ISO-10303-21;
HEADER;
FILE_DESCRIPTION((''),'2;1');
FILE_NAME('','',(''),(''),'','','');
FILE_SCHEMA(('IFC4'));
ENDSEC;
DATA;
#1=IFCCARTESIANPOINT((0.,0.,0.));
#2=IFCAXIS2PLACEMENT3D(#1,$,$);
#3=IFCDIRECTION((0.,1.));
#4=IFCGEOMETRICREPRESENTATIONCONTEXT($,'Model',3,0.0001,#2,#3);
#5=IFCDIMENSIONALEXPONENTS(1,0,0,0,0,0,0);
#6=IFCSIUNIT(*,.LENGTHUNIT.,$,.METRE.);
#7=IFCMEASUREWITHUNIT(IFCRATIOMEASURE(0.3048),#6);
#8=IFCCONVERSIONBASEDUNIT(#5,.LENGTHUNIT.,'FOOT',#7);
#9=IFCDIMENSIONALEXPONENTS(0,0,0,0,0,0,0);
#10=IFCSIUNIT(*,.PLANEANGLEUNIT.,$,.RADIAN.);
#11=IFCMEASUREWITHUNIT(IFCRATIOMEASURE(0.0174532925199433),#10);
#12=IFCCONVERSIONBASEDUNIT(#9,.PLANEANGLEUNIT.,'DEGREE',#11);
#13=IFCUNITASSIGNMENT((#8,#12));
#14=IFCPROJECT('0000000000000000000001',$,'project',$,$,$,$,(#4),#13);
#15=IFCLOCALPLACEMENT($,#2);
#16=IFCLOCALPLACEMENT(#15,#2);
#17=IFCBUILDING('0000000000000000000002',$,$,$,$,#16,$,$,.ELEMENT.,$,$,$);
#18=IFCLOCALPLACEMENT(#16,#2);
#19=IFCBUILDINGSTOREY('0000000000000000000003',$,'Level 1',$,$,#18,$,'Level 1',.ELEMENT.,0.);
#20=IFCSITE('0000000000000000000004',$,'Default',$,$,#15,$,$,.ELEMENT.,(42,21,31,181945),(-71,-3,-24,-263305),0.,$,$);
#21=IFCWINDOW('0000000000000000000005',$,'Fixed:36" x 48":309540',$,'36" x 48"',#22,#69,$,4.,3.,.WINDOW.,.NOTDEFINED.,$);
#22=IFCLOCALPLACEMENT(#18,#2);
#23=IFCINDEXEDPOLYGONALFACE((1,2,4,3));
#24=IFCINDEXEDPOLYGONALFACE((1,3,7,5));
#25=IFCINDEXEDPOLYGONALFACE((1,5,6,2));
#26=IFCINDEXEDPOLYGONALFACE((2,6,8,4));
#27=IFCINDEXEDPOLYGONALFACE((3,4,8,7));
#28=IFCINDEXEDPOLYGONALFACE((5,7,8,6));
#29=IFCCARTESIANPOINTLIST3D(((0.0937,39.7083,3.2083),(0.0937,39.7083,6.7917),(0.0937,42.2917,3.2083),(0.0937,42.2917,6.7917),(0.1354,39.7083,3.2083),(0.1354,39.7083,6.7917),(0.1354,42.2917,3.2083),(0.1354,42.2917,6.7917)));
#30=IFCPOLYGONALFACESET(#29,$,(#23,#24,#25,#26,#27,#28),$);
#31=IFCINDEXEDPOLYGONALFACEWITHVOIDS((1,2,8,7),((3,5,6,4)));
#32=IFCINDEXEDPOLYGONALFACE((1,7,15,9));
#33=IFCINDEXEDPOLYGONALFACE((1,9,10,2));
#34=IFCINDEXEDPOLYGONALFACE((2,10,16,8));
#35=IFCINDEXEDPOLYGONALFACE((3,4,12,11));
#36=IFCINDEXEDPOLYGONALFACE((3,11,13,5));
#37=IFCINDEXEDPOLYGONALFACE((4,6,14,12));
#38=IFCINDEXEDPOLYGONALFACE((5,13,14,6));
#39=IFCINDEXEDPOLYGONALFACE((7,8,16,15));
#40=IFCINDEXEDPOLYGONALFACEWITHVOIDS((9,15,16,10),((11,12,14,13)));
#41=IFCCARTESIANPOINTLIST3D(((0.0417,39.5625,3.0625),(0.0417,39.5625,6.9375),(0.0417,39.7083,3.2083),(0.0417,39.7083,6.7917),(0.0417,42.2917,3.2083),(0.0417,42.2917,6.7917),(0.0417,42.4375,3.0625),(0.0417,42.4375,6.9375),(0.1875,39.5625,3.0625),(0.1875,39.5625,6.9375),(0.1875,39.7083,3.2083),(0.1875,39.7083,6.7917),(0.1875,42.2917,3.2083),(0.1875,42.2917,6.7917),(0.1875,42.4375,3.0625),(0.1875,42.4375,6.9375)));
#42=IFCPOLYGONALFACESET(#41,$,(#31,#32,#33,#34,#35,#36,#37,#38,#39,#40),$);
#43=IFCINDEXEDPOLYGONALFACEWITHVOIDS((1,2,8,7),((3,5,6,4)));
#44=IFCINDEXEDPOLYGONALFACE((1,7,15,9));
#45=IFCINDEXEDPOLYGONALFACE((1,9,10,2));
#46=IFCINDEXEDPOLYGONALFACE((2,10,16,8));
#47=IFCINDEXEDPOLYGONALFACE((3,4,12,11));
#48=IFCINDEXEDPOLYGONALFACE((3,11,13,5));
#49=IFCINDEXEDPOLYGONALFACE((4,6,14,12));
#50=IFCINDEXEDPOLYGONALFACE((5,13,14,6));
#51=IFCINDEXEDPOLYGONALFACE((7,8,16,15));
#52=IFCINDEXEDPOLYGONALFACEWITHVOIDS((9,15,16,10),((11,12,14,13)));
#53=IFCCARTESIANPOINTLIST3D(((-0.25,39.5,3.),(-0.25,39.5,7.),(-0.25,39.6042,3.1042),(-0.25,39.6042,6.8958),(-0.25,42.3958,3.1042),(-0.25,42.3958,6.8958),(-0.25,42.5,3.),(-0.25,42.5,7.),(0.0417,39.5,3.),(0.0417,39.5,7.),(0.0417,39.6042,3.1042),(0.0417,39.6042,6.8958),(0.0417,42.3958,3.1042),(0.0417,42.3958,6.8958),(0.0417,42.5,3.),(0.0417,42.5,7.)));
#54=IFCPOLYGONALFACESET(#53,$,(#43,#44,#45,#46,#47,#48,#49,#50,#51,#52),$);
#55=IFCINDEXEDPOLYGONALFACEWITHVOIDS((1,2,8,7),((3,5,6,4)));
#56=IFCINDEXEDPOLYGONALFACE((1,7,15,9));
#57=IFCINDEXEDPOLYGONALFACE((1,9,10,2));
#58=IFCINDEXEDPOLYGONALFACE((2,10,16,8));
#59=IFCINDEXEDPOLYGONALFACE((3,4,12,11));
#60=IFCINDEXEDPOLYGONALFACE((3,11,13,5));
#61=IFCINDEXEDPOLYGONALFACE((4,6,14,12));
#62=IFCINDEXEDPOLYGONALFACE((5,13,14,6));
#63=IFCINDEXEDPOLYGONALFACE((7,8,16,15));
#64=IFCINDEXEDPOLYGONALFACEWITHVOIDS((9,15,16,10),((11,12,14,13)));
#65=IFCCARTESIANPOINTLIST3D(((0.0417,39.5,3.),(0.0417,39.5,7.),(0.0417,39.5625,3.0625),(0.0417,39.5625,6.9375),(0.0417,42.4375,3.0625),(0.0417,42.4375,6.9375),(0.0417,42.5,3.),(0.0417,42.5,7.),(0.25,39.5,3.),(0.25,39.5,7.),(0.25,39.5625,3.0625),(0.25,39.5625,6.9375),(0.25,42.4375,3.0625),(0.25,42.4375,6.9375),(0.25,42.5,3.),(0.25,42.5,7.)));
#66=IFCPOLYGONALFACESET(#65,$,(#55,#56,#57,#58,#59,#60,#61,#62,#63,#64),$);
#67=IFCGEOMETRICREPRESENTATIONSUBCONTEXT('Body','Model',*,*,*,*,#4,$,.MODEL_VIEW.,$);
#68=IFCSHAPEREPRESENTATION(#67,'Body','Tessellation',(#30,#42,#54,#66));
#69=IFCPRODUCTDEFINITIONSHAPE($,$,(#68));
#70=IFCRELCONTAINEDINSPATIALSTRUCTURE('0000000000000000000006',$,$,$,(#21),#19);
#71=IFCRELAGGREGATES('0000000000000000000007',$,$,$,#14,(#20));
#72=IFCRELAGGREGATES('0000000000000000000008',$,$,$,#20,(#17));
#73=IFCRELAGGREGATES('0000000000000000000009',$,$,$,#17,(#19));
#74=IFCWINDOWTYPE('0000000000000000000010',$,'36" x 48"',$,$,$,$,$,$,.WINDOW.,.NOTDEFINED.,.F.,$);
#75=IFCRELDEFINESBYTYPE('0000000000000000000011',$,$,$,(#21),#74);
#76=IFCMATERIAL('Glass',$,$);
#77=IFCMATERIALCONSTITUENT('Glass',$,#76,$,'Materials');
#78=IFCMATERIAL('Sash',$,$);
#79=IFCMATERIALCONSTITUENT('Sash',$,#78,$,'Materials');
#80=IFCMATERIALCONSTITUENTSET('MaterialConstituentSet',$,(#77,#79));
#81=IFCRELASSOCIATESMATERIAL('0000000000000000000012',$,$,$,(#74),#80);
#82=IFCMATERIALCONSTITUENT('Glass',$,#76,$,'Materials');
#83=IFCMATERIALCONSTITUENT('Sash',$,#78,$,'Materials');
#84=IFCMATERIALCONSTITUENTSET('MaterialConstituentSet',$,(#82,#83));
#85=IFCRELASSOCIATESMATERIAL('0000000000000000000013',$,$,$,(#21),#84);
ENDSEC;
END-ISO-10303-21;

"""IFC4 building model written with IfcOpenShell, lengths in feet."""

from ifc_helpers import new_model, entity, si_unit, converted_unit, direction, frame, frame_2d, origin, place, context, subcontext, project, spatial, polyline, rectangle, outline, extrude, source, transform, mapped, material, constituent, constituent_set, type_object, type_shapes, element, save


model = new_model("IFC4")

# Units and contexts
model_context = context("Model", 3, precision=0.0001, world=origin(), true_north=direction((0.0, 1.0)))
body_context = subcontext(model_context, "Body", "Model", "MODEL_VIEW")
ifc_project = project(units=[converted_unit("LENGTHUNIT", "FOOT", entity("IfcRatioMeasure", 0.3048), si_unit("LENGTHUNIT", "METRE"), dimensions=[1, 0, 0, 0, 0, 0, 0]), converted_unit("PLANEANGLEUNIT", "DEGREE", entity("IfcRatioMeasure", 0.0174532925199433), si_unit("PLANEANGLEUNIT", "RADIAN"), dimensions=[0, 0, 0, 0, 0, 0, 0])], contexts=[model_context])

# Site, building, storey
site_placement = place(None, origin())
site = spatial("IfcSite", under=ifc_project, at=site_placement, Name="Default", CompositionType="ELEMENT", RefLatitude=(42, 21, 31, 181945), RefLongitude=(-71, -3, -24, -263305), RefElevation=0.0)
building_placement = place(site_placement, origin())
building = spatial("IfcBuilding", under=site, at=building_placement, CompositionType="ELEMENT")
storey_placement = place(building_placement, origin())
storey = spatial("IfcBuildingStorey", under=building, at=storey_placement, Name="Level 1", LongName="Level 1", CompositionType="ELEMENT", Elevation=0.0)

# Shared definitions
placement_1 = place(storey_placement, frame((0.0, -0.25, 0.0), z_axis=(0.0, 0.0, 1.0), x_axis=(0.0, 1.0, 0.0)))

# Window
ifc_material_1 = material(Name="Glass")
ifc_constituent_1 = constituent(ifc_material_1, Name="Glass", Category="Materials")
ifc_material_2 = material(Name="Sash")
ifc_constituent_2 = constituent(ifc_material_2, Name="Sash", Category="Materials")
ifc_constituent_set_1 = constituent_set(constituents=[ifc_constituent_1, ifc_constituent_2], Name="MaterialConstituentSet")
ifc_constituent_3 = constituent(ifc_material_1, Name="Glass", Category="Materials")
ifc_constituent_4 = constituent(ifc_material_2, Name="Sash", Category="Materials")
ifc_constituent_set_2 = constituent_set(constituents=[ifc_constituent_3, ifc_constituent_4], Name="MaterialConstituentSet")
window_type = type_object("IfcWindowType", Name="36\" x 48\"", ParameterTakesPrecedence=False, PartitioningType="NOTDEFINED", PredefinedType="WINDOW", material=ifc_constituent_set_2)
shared_shape = source(origin(), body_context, "Body", "SweptSolid", [
    extrude(rectangle(XDim=0.0417, YDim=2.5833, at=frame_2d((0.0, 0.0), x_axis=(1.0, 0.0))), frame((1.5, 0.3646, 0.2083), z_axis=(0.0, 0.0, 1.0), x_axis=(0.0, 1.0, 0.0)), (0.0, 0.0, 1.0), 3.5833),
    extrude(outline(polyline([(-1.4375, -1.9375), (1.4375, -1.9375), (1.4375, 1.9375), (-1.4375, 1.9375), (-1.4375, -1.9375)]), holes=[polyline([(-1.2917, -1.7917), (-1.2917, 1.7917), (1.2917, 1.7917), (1.2917, -1.7917), (-1.2917, -1.7917)])]), frame((1.5, 0.2917, 2.0), z_axis=(0.0, 1.0, 0.0), x_axis=(1.0, 0.0, 0.0)), (0.0, 0.0, 1.0), 0.1458),
    extrude(outline(polyline([(-1.5, -2.0), (1.5, -2.0), (1.5, 2.0), (-1.5, 2.0), (-1.5, -2.0)]), holes=[polyline([(-1.3958, -1.8958), (-1.3958, 1.8958), (1.3958, 1.8958), (1.3958, -1.8958), (-1.3958, -1.8958)])]), frame((1.5, 0.0, 2.0), z_axis=(0.0, 1.0, 0.0), x_axis=(1.0, 0.0, 0.0)), (0.0, 0.0, 1.0), 0.2917),
    extrude(outline(polyline([(-2.0, -1.5), (2.0, -1.5), (2.0, 1.5), (-2.0, 1.5), (-2.0, -1.5)]), holes=[polyline([(-1.9375, -1.4375), (-1.9375, 1.4375), (1.9375, 1.4375), (1.9375, -1.4375), (-1.9375, -1.4375)])]), frame((1.5, 0.2917, 2.0), z_axis=(0.0, 1.0, 0.0), x_axis=(0.0, 0.0, -1.0)), (0.0, 0.0, 1.0), 0.2083),
])
type_shapes(window_type, [shared_shape])
placement_2 = place(placement_1, frame((42.75, 0.25, 3.0)))
window_placement = place(placement_2, frame((0.0, 0.0, 0.0), z_axis=(0.0, 0.0, 1.0), x_axis=(-1.0, 0.0, 0.0)))
element("IfcWindow", 1, at=window_placement, inside=storey, type_object=window_type, material=ifc_constituent_set_1, Name="Fixed:36\" x 48\":309540", ObjectType="36\" x 48\"", OverallHeight=4.0, OverallWidth=3.0, PartitioningType="NOTDEFINED", PredefinedType="WINDOW", context=body_context, shape_type="MappedRepresentation", body=[
    mapped(shared_shape, transform((0.0, 0.0, 0.0), scale=1.0)),
])

save(model, "model.ifc")
